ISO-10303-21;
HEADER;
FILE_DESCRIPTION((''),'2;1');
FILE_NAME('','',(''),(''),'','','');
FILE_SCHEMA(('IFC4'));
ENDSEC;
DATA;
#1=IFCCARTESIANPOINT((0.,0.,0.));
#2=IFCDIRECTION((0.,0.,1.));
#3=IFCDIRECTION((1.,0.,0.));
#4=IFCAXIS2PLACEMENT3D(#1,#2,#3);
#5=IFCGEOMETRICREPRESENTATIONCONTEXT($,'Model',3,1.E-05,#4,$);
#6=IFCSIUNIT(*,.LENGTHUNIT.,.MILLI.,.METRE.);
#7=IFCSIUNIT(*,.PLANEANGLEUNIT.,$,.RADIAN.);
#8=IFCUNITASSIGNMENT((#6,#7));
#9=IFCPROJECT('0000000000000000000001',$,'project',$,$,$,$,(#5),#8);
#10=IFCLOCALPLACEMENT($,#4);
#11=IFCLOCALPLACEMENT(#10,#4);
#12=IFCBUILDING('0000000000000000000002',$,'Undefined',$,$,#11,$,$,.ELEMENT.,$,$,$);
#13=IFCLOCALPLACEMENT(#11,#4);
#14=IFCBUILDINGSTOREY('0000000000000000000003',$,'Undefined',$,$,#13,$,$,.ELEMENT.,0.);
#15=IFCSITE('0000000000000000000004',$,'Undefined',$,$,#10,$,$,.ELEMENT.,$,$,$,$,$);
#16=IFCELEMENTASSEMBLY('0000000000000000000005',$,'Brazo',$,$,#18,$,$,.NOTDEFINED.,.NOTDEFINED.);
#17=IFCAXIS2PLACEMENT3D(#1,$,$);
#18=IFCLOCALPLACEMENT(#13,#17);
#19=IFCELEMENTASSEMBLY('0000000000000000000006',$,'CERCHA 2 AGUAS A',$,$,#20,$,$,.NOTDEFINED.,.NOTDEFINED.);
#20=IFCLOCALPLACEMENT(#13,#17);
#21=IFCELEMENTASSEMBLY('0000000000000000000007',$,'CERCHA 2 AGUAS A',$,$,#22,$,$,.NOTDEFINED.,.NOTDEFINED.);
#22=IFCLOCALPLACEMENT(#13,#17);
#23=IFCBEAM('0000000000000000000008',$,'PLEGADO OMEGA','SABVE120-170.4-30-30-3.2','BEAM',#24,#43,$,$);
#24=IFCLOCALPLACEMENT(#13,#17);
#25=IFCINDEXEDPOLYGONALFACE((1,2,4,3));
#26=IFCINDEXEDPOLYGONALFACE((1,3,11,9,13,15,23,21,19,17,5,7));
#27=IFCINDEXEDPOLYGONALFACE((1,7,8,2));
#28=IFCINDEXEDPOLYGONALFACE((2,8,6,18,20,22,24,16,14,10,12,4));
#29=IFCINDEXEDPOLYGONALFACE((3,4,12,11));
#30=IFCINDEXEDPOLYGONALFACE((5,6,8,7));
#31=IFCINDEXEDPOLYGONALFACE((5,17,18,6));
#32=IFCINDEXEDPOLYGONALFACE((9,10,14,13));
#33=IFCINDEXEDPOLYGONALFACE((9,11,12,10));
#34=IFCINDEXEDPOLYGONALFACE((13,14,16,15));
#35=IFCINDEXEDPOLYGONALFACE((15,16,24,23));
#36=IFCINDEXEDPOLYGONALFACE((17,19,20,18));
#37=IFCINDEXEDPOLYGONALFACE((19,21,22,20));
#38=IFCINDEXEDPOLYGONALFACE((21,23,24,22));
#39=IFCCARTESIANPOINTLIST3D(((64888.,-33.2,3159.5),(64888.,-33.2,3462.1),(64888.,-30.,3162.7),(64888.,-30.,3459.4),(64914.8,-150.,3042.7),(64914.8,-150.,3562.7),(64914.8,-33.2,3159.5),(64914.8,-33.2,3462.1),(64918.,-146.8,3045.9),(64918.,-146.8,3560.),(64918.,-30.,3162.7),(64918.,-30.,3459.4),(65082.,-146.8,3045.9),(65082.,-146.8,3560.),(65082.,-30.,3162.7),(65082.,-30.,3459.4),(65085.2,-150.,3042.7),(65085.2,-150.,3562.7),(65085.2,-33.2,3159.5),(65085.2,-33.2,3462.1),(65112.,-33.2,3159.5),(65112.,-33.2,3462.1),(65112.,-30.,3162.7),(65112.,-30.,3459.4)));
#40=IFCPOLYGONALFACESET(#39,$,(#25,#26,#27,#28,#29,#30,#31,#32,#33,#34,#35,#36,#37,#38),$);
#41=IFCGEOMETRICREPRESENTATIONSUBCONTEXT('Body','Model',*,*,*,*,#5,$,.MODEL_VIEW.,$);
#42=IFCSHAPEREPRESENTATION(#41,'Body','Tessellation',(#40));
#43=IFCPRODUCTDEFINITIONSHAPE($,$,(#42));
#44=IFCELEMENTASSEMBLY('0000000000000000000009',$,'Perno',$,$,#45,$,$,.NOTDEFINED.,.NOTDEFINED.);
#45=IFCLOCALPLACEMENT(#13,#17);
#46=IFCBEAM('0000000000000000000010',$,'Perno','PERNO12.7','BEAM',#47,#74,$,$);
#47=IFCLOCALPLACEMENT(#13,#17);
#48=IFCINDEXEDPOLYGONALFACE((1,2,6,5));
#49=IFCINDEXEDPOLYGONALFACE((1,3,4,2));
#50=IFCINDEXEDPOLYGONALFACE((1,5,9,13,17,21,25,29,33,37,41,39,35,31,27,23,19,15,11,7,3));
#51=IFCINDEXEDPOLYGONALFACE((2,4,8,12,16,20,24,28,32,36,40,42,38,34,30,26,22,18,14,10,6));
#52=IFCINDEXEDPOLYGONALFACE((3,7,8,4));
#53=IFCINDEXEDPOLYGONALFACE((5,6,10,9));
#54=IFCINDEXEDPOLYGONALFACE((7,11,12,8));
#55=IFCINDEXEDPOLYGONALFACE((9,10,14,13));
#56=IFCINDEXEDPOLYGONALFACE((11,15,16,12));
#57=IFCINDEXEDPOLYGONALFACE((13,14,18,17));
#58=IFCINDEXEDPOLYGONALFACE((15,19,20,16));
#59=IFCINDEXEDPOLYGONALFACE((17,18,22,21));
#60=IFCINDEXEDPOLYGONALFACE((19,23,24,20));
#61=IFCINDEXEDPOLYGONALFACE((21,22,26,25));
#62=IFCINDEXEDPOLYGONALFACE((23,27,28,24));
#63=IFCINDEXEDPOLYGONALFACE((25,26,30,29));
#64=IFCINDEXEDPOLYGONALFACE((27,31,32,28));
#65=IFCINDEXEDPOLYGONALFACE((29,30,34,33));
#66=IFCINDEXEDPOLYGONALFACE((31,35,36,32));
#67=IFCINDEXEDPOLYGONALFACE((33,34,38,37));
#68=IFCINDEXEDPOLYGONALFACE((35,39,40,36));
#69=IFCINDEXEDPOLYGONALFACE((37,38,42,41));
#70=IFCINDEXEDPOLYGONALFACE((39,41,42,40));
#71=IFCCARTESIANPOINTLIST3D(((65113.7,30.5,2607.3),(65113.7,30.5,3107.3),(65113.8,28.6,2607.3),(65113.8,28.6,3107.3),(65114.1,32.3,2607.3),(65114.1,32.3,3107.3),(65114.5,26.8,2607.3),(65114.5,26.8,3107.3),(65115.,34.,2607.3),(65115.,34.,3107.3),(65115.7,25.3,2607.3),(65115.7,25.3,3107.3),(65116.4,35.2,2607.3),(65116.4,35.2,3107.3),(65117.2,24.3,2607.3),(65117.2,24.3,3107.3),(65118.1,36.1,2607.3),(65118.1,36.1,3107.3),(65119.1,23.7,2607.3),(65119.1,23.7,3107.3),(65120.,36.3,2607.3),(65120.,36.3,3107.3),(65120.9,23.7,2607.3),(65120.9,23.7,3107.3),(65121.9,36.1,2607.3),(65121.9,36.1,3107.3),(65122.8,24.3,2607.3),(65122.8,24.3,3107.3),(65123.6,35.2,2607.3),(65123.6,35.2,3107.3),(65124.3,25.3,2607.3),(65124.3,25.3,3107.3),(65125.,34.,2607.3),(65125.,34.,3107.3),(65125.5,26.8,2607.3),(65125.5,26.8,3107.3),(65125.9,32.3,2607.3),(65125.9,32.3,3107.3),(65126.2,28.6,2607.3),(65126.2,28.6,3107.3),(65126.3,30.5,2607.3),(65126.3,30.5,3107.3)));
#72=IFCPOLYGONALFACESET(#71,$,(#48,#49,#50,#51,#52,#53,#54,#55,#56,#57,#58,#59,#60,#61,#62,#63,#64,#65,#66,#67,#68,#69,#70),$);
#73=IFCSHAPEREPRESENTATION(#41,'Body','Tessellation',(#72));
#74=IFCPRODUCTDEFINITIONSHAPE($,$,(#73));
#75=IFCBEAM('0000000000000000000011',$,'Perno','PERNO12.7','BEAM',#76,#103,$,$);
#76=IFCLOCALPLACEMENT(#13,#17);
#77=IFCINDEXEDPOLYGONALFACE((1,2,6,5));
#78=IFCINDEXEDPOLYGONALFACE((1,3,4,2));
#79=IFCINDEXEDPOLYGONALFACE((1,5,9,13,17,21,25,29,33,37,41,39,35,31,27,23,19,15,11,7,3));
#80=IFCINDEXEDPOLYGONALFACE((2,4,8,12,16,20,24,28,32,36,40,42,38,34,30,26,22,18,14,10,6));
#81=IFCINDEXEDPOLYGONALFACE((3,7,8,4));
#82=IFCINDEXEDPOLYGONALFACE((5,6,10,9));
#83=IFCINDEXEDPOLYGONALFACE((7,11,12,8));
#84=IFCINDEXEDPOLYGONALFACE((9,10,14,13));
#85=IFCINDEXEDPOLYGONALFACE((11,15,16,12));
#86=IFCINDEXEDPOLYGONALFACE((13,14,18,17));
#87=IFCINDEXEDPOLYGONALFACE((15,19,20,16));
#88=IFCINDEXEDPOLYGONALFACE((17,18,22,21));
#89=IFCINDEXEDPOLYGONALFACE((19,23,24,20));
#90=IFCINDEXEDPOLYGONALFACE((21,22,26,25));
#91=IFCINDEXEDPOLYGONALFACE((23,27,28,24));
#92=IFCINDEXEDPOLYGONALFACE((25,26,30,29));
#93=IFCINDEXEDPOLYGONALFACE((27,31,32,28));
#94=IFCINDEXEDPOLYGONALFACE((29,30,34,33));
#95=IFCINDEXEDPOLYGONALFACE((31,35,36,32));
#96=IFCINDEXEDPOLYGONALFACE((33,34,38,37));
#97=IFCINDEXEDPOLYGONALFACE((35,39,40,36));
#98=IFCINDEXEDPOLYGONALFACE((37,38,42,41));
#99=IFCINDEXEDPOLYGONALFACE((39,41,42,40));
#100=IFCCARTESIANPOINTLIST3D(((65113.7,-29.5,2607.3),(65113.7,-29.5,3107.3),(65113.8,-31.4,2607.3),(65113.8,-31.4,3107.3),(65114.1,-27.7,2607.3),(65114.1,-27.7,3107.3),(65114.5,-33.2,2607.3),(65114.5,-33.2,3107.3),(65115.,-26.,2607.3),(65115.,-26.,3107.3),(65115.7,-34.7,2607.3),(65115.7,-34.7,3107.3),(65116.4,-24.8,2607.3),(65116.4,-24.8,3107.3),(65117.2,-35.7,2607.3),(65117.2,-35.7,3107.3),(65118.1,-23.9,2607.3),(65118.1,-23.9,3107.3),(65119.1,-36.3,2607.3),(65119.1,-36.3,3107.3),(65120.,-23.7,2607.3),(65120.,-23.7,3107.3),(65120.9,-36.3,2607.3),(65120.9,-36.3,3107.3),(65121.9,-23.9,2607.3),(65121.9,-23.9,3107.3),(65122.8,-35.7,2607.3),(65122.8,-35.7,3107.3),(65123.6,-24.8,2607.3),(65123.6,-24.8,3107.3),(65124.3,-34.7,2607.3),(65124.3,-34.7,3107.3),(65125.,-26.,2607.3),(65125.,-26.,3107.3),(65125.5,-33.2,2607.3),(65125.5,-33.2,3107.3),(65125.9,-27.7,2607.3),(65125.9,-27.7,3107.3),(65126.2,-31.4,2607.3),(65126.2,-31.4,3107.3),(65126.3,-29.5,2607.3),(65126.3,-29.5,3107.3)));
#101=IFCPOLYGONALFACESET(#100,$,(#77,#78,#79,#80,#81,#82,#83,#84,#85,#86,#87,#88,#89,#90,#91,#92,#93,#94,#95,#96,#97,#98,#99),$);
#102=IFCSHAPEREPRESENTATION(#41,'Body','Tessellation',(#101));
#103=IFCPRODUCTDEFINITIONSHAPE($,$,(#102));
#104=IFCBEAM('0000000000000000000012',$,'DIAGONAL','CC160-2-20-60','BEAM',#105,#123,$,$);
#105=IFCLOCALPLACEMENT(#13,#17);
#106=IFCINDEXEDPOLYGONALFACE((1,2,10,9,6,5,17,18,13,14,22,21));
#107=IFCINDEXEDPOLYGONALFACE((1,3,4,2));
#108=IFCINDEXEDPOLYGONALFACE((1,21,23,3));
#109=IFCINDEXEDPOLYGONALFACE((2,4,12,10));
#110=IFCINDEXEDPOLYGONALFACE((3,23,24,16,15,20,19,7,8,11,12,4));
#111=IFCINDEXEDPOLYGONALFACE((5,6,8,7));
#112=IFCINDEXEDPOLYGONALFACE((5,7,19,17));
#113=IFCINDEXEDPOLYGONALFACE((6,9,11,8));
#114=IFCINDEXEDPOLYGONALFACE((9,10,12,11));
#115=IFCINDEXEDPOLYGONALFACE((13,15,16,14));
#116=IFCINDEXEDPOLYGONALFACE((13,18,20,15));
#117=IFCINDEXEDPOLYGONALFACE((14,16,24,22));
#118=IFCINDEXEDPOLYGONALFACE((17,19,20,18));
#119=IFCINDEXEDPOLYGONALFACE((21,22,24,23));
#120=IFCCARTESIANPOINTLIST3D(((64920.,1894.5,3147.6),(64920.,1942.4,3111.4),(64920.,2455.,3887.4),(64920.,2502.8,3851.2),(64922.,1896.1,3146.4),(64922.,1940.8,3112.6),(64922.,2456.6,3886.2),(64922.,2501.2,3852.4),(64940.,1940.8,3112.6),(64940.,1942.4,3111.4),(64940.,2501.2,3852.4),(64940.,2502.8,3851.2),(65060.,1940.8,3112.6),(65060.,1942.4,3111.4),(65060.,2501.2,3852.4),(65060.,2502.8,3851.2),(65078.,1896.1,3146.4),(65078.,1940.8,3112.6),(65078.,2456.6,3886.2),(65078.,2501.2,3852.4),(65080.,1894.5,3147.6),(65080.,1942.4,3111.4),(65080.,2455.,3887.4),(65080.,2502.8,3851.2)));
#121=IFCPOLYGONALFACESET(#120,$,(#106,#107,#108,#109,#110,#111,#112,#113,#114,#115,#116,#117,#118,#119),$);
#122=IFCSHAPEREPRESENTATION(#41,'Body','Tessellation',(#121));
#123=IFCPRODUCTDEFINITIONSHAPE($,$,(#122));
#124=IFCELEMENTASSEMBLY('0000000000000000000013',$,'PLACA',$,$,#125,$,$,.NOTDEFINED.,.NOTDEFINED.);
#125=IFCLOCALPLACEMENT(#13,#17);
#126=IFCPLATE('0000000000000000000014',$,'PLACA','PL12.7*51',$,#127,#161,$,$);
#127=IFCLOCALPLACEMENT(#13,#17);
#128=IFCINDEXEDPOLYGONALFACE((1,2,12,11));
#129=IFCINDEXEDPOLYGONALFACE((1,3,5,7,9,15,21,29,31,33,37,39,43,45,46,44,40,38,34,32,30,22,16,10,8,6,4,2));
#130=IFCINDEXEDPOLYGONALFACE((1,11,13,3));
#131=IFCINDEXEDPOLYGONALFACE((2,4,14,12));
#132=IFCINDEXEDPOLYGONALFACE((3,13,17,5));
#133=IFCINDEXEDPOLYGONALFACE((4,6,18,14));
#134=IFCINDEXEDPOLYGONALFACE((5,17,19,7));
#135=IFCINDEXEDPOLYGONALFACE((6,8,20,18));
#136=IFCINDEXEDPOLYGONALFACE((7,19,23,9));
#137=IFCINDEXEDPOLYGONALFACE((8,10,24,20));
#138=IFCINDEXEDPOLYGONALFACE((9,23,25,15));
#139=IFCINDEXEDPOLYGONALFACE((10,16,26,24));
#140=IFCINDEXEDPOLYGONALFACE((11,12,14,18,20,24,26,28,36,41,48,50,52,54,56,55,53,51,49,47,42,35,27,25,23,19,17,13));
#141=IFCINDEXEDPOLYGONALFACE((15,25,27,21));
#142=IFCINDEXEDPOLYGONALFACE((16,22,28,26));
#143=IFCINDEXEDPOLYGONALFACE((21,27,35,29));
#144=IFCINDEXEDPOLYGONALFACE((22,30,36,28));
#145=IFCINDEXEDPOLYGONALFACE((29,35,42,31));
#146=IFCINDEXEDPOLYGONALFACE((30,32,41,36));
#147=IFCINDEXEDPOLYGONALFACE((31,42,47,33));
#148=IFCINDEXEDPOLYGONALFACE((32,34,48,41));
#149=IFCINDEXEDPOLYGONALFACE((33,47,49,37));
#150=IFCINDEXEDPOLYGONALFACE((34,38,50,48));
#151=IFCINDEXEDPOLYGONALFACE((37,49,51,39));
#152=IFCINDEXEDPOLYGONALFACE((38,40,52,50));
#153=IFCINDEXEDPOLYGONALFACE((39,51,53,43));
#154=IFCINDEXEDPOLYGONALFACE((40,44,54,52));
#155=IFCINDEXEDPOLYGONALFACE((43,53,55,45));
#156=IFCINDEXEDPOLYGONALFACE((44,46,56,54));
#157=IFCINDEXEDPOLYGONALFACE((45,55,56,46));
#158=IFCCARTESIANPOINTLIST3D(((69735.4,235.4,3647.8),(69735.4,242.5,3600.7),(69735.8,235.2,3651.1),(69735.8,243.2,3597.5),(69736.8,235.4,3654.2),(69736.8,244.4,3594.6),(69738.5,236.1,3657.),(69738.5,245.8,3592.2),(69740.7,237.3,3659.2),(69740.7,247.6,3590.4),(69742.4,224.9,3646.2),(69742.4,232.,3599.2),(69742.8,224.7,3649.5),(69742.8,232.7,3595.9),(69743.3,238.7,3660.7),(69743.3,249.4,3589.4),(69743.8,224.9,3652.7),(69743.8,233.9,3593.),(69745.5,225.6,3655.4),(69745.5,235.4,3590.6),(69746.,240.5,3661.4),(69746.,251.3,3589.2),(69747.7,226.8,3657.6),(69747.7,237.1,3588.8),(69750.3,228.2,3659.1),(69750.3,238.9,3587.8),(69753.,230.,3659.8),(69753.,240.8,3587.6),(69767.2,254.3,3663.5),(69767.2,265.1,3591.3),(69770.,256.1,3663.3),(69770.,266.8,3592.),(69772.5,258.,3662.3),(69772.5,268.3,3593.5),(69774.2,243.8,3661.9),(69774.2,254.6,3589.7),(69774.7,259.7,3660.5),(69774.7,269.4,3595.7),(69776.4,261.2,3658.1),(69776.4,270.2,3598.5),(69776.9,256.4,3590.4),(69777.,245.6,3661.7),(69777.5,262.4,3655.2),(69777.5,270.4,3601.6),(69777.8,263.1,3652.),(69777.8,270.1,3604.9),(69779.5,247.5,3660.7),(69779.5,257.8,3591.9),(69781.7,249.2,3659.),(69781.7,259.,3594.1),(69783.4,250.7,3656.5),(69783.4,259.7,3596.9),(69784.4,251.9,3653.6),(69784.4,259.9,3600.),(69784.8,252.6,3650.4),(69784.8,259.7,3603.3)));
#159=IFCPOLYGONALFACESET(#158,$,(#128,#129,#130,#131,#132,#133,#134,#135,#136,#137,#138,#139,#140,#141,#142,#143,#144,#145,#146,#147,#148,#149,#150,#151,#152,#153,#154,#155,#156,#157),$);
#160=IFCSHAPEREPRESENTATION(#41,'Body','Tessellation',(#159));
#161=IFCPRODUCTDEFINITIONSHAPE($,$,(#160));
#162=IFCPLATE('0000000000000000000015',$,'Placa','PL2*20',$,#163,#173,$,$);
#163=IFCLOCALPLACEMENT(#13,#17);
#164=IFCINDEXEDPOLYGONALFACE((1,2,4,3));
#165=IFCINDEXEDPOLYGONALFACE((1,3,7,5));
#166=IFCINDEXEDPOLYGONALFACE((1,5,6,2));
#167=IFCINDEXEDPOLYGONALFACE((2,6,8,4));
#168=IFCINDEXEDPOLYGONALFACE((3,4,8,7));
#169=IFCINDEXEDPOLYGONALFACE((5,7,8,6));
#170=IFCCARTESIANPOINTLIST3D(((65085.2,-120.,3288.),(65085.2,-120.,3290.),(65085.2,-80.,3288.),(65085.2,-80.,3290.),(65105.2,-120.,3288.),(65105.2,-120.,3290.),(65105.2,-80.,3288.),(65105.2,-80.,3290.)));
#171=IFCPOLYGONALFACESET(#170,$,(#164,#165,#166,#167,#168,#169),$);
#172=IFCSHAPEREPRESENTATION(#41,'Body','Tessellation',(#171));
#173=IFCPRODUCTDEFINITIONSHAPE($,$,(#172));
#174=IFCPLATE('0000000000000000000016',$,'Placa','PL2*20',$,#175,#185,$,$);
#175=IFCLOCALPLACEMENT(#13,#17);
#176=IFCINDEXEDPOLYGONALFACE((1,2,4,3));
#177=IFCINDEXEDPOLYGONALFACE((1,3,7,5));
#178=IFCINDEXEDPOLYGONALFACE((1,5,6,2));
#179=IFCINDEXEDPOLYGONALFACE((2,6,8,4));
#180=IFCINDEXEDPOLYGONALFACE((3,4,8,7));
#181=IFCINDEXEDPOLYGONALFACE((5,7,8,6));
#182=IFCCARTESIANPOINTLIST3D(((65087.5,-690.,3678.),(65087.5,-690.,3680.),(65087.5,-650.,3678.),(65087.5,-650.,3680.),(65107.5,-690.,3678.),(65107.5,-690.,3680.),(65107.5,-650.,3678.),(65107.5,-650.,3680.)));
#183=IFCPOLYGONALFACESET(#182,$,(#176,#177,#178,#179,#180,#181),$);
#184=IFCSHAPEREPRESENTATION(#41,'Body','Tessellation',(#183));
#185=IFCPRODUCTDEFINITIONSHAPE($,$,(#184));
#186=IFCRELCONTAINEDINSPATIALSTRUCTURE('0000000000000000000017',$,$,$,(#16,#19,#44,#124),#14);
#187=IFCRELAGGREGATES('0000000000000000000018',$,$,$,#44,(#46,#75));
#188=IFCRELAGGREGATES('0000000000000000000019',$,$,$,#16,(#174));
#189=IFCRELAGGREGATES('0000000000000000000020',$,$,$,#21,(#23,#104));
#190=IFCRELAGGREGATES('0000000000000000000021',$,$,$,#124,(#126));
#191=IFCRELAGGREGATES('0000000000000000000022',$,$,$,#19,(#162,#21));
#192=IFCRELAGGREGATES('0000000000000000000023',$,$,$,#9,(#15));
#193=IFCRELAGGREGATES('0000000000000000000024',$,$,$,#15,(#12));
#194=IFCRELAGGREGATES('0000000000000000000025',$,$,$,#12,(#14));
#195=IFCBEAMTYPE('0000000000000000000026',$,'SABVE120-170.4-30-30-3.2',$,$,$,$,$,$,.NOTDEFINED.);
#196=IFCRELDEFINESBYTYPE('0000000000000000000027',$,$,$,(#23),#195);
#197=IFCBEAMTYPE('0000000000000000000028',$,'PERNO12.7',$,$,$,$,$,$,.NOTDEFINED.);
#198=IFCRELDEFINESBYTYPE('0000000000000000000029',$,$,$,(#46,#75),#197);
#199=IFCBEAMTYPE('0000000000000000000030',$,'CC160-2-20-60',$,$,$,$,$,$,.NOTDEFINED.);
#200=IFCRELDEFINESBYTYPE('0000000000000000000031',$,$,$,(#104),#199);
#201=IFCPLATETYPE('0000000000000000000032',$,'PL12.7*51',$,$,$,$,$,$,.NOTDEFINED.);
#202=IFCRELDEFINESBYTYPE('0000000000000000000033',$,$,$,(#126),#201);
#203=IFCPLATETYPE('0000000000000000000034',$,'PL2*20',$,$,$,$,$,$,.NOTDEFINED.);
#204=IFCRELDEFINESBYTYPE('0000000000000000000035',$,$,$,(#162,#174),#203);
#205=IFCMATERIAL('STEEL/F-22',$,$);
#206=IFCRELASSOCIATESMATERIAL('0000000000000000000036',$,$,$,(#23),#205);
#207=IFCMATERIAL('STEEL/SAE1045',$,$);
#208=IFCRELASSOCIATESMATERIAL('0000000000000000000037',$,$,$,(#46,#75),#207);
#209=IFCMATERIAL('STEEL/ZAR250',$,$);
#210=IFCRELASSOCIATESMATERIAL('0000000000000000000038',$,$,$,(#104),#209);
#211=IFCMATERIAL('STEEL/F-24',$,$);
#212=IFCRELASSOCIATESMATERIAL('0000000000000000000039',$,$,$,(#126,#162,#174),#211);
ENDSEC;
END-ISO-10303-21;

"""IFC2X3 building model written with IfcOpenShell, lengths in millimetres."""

from ifc_helpers import new_model, si_unit, frame, frame_2d, origin_with_axes, origin_2d_with_axis, place, context, subcontext, project, spatial, polyline, circle_curve, parameter, trimmed, segment, composite_curve, circle, c_section, outline, extrude, clip, halfspace, material, type_object, element, aggregate, save


model = new_model("IFC2X3")

# Units and contexts
model_context = context("Model", 3, precision=1e-05, world=origin_with_axes())
body_context = subcontext(model_context, "Body", "Model", "MODEL_VIEW")
ifc_project = project(units=[si_unit("LENGTHUNIT", "METRE", prefix="MILLI"), si_unit("PLANEANGLEUNIT", "RADIAN")], contexts=[model_context])

# Site, building, storey
site_placement = place(None, origin_with_axes())
site = spatial("IfcSite", under=ifc_project, at=site_placement, Name="Undefined", CompositionType="ELEMENT")
building_placement = place(site_placement, origin_with_axes())
building = spatial("IfcBuilding", under=site, at=building_placement, Name="Undefined", CompositionType="ELEMENT")
storey_placement = place(building_placement, origin_with_axes())
storey = spatial("IfcBuildingStorey", under=building, at=storey_placement, Name="Undefined", CompositionType="ELEMENT", Elevation=0.0)

# Shared definitions
ifc_material_1 = material(Name="STEEL/F-24")

# Element assembly
assembly_1_placement = place(storey_placement, origin_with_axes())
assembly_1 = element("IfcElementAssembly", 1, at=assembly_1_placement, inside=storey, Name="Brazo", AssemblyPlace="NOTDEFINED", PredefinedType="NOTDEFINED")
ifc_material_2 = material(Name="STEEL/ZAR250")

# Element assemblies, beam
assembly_2_placement = place(storey_placement, origin_with_axes())
assembly_2 = element("IfcElementAssembly", 2, at=assembly_2_placement, inside=storey, Name="CERCHA 2 AGUAS A", AssemblyPlace="NOTDEFINED", PredefinedType="NOTDEFINED")
assembly_3_placement = place(assembly_2_placement, origin_with_axes())
assembly_3 = element("IfcElementAssembly", 3, at=assembly_3_placement, Name="CERCHA 2 AGUAS A", AssemblyPlace="NOTDEFINED", PredefinedType="NOTDEFINED")
ifc_material_3 = material(Name="STEEL/F-22")
beam_type_1 = type_object("IfcBeamType", Name="SABVE120-170.4-30-30-3.2", PredefinedType="NOTDEFINED")
beam_1_placement = place(assembly_3_placement, frame((65000.0, -90.0, 3042.7), z_axis=(0.0, 1.0, -0.000004), x_axis=(0.0, 0.000004, 1.0)))
beam_1 = element("IfcBeam", 4, at=beam_1_placement, type_object=beam_type_1, material=ifc_material_3, Name="PLEGADO OMEGA", Description="SABVE120-170.4-30-30-3.2", ObjectType="BEAM", context=body_context, shape_type="Clipping", body=[
    clip(clip(extrude(outline(polyline([(82.0, 60.0), (112.0, 60.0), (112.0, 56.8), (85.2, 56.8), (85.2, -60.0), (-85.2, -60.0), (-85.2, 56.8), (-112.0, 56.8), (-112.0, 60.0), (-82.0, 60.0), (-82.0, -56.8), (82.0, -56.8), (82.0, 60.0)])), frame((581.1, 0.0, 0.0), z_axis=(-1.0, 0.0, 0.0), x_axis=(0.0, -1.0, 0.0)), (0.0, 0.0, 1.0), 633.9), halfspace(frame((520.0, 0.0, -60.0), z_axis=(-0.757741, 0.0, -0.652555), x_axis=(0.0, 1.0, 0.0)), True)), halfspace(frame((120.0, 0.0, 60.0), z_axis=(0.707106, 0.0, -0.707108), x_axis=(0.0, 1.0, 0.0)), True)),
])

# Element assembly, beams
assembly_4_placement = place(storey_placement, origin_with_axes())
assembly_4 = element("IfcElementAssembly", 5, at=assembly_4_placement, inside=storey, Name="Perno", AssemblyPlace="NOTDEFINED", PredefinedType="NOTDEFINED")
ifc_material_4 = material(Name="STEEL/SAE1045")
beam_type_2 = type_object("IfcBeamType", Name="PERNO12.7", PredefinedType="NOTDEFINED")
beam_2_placement = place(assembly_4_placement, frame((65120.0, 30.0, 3107.3), z_axis=(-1.0, 0.0, 0.0), x_axis=(0.0, 0.0, -1.0)))
beam_2 = element("IfcBeam", 6, at=beam_2_placement, type_object=beam_type_2, material=ifc_material_4, Name="Perno", Description="PERNO12.7", ObjectType="BEAM", context=body_context, shape_type="SweptSolid", body=[
    extrude(circle(Radius=6.3, at=origin_2d_with_axis()), frame((500.0, 0.0, 0.0), z_axis=(-1.0, 0.0, 0.0), x_axis=(0.0, -1.0, 0.0)), (0.0, 0.0, 1.0), 500.0),
])
beam_3_placement = place(assembly_4_placement, frame((65120.0, -30.0, 3107.3), z_axis=(-1.0, 0.0, 0.0), x_axis=(0.0, 0.0, -1.0)))
beam_3 = element("IfcBeam", 7, at=beam_3_placement, type_object=beam_type_2, material=ifc_material_4, Name="Perno", Description="PERNO12.7", ObjectType="BEAM", context=body_context, shape_type="SweptSolid", body=[
    extrude(circle(Radius=6.3, at=origin_2d_with_axis()), frame((500.0, 0.0, 0.0), z_axis=(-1.0, 0.0, 0.0), x_axis=(0.0, -1.0, 0.0)), (0.0, 0.0, 1.0), 500.0),
])
aggregate(assembly_4, [beam_2, beam_3])

# Beam
beam_type_3 = type_object("IfcBeamType", Name="CC160-2-20-60", PredefinedType="NOTDEFINED")
beam_4_placement = place(assembly_3_placement, frame((65000.0, 1918.5, 3129.5), z_axis=(1.0, 0.0, 0.0), x_axis=(0.0, 0.603858, 0.797092)))
beam_4 = element("IfcBeam", 8, at=beam_4_placement, type_object=beam_type_3, material=ifc_material_2, Name="DIAGONAL", Description="CC160-2-20-60", ObjectType="BEAM", context=body_context, shape_type="SweptSolid", body=[
    extrude(c_section(Depth=160.0, Width=60.0, WallThickness=2.0, Girth=20.0, at=origin_2d_with_axis()), frame((928.1, 0.0, 0.0), z_axis=(-1.0, 0.0, 0.0), x_axis=(0.0, -1.0, 0.0)), (0.0, 0.0, 1.0), 928.1),
])

# Element assembly, plate
assembly_5_placement = place(storey_placement, origin_with_axes())
assembly_5 = element("IfcElementAssembly", 9, at=assembly_5_placement, inside=storey, Name="PLACA", AssemblyPlace="NOTDEFINED", PredefinedType="NOTDEFINED")
plate_type_1 = type_object("IfcPlateType", Name="PL12.7*51", PredefinedType="NOTDEFINED")
plate_1_placement = place(assembly_5_placement, frame((69738.9, 228.3, 3659.6), z_axis=(0.550431, -0.825638, -0.123885), x_axis=(-0.00002, 0.148374, -0.988931)))
plate_1 = element("IfcPlate", 10, at=plate_1_placement, type_object=plate_type_1, material=ifc_material_1, Name="PLACA", Description="PL12.7*51", context=body_context, shape_type="SweptSolid", body=[
    extrude(outline(composite_curve([segment(trimmed(circle_curve(frame_2d((12.7, 12.7), x_axis=(-1.0, 0.0)), 12.7), [parameter(0.0)], [parameter(1.570796)], True, "PARAMETER"), True, "CONTINUOUS"), segment(polyline([(12.7, 0.0), (60.3, 0.0)]), True, "CONTINUOUS"), segment(trimmed(circle_curve(frame_2d((60.3, 12.7), x_axis=(0.0, -1.0)), 12.7), [parameter(0.0)], [parameter(1.570796)], True, "PARAMETER"), True, "CONTINUOUS"), segment(polyline([(73.0, 12.7), (73.0, 38.1)]), True, "CONTINUOUS"), segment(trimmed(circle_curve(frame_2d((60.3, 38.1), x_axis=(1.0, 0.0)), 12.7), [parameter(0.0)], [parameter(1.570796)], True, "PARAMETER"), True, "CONTINUOUS"), segment(polyline([(60.3, 50.8), (12.7, 50.8)]), True, "CONTINUOUS"), segment(trimmed(circle_curve(frame_2d((12.7, 38.1), x_axis=(0.0, 1.0)), 12.7), [parameter(0.0)], [parameter(1.570796)], True, "PARAMETER"), True, "CONTINUOUS"), segment(polyline([(0.0, 38.1), (0.0, 12.7)]), True, "CONTINUOUS")], self_intersect=True)), frame((0.0, 0.0, -6.3), z_axis=(0.0, 0.0, 1.0), x_axis=(1.0, 0.0, 0.0)), (0.0, 0.0, 1.0), 12.7),
])

# Plates
plate_type_2 = type_object("IfcPlateType", Name="PL2*20", PredefinedType="NOTDEFINED")
plate_2_placement = place(assembly_2_placement, frame((65105.2, -120.0, 3289.0), z_axis=(0.0, -0.000121, 1.0), x_axis=(0.000085, 1.0, 0.000121)))
plate_2 = element("IfcPlate", 11, at=plate_2_placement, type_object=plate_type_2, material=ifc_material_1, Name="Placa", Description="PL2*20", context=body_context, shape_type="SweptSolid", body=[
    extrude(outline(polyline([(0.0, 0.0), (40.0, 0.0), (40.0, 20.0), (0.0, 20.0), (0.0, 0.0)])), frame((0.0, 0.0, -1.0), z_axis=(0.0, 0.0, 1.0), x_axis=(1.0, 0.0, 0.0)), (0.0, 0.0, 1.0), 2.0),
])
plate_3_placement = place(assembly_1_placement, frame((65087.5, -690.0, 3679.0), z_axis=(0.0, 0.000121, -1.0), x_axis=(-0.000071, 1.0, 0.000121)))
plate_3 = element("IfcPlate", 12, at=plate_3_placement, type_object=plate_type_2, material=ifc_material_1, Name="Placa", Description="PL2*20", context=body_context, shape_type="SweptSolid", body=[
    extrude(outline(polyline([(0.0, 0.0), (40.0, 0.0), (40.0, 20.0), (0.0, 20.0), (0.0, 0.0)])), frame((0.0, 0.0, -1.0), z_axis=(0.0, 0.0, 1.0), x_axis=(1.0, 0.0, 0.0)), (0.0, 0.0, 1.0), 2.0),
])
aggregate(assembly_1, [plate_3])
aggregate(assembly_3, [beam_1, beam_4])

aggregate(assembly_5, [plate_1])

aggregate(assembly_2, [plate_2, assembly_3])

save(model, "model.ifc")
